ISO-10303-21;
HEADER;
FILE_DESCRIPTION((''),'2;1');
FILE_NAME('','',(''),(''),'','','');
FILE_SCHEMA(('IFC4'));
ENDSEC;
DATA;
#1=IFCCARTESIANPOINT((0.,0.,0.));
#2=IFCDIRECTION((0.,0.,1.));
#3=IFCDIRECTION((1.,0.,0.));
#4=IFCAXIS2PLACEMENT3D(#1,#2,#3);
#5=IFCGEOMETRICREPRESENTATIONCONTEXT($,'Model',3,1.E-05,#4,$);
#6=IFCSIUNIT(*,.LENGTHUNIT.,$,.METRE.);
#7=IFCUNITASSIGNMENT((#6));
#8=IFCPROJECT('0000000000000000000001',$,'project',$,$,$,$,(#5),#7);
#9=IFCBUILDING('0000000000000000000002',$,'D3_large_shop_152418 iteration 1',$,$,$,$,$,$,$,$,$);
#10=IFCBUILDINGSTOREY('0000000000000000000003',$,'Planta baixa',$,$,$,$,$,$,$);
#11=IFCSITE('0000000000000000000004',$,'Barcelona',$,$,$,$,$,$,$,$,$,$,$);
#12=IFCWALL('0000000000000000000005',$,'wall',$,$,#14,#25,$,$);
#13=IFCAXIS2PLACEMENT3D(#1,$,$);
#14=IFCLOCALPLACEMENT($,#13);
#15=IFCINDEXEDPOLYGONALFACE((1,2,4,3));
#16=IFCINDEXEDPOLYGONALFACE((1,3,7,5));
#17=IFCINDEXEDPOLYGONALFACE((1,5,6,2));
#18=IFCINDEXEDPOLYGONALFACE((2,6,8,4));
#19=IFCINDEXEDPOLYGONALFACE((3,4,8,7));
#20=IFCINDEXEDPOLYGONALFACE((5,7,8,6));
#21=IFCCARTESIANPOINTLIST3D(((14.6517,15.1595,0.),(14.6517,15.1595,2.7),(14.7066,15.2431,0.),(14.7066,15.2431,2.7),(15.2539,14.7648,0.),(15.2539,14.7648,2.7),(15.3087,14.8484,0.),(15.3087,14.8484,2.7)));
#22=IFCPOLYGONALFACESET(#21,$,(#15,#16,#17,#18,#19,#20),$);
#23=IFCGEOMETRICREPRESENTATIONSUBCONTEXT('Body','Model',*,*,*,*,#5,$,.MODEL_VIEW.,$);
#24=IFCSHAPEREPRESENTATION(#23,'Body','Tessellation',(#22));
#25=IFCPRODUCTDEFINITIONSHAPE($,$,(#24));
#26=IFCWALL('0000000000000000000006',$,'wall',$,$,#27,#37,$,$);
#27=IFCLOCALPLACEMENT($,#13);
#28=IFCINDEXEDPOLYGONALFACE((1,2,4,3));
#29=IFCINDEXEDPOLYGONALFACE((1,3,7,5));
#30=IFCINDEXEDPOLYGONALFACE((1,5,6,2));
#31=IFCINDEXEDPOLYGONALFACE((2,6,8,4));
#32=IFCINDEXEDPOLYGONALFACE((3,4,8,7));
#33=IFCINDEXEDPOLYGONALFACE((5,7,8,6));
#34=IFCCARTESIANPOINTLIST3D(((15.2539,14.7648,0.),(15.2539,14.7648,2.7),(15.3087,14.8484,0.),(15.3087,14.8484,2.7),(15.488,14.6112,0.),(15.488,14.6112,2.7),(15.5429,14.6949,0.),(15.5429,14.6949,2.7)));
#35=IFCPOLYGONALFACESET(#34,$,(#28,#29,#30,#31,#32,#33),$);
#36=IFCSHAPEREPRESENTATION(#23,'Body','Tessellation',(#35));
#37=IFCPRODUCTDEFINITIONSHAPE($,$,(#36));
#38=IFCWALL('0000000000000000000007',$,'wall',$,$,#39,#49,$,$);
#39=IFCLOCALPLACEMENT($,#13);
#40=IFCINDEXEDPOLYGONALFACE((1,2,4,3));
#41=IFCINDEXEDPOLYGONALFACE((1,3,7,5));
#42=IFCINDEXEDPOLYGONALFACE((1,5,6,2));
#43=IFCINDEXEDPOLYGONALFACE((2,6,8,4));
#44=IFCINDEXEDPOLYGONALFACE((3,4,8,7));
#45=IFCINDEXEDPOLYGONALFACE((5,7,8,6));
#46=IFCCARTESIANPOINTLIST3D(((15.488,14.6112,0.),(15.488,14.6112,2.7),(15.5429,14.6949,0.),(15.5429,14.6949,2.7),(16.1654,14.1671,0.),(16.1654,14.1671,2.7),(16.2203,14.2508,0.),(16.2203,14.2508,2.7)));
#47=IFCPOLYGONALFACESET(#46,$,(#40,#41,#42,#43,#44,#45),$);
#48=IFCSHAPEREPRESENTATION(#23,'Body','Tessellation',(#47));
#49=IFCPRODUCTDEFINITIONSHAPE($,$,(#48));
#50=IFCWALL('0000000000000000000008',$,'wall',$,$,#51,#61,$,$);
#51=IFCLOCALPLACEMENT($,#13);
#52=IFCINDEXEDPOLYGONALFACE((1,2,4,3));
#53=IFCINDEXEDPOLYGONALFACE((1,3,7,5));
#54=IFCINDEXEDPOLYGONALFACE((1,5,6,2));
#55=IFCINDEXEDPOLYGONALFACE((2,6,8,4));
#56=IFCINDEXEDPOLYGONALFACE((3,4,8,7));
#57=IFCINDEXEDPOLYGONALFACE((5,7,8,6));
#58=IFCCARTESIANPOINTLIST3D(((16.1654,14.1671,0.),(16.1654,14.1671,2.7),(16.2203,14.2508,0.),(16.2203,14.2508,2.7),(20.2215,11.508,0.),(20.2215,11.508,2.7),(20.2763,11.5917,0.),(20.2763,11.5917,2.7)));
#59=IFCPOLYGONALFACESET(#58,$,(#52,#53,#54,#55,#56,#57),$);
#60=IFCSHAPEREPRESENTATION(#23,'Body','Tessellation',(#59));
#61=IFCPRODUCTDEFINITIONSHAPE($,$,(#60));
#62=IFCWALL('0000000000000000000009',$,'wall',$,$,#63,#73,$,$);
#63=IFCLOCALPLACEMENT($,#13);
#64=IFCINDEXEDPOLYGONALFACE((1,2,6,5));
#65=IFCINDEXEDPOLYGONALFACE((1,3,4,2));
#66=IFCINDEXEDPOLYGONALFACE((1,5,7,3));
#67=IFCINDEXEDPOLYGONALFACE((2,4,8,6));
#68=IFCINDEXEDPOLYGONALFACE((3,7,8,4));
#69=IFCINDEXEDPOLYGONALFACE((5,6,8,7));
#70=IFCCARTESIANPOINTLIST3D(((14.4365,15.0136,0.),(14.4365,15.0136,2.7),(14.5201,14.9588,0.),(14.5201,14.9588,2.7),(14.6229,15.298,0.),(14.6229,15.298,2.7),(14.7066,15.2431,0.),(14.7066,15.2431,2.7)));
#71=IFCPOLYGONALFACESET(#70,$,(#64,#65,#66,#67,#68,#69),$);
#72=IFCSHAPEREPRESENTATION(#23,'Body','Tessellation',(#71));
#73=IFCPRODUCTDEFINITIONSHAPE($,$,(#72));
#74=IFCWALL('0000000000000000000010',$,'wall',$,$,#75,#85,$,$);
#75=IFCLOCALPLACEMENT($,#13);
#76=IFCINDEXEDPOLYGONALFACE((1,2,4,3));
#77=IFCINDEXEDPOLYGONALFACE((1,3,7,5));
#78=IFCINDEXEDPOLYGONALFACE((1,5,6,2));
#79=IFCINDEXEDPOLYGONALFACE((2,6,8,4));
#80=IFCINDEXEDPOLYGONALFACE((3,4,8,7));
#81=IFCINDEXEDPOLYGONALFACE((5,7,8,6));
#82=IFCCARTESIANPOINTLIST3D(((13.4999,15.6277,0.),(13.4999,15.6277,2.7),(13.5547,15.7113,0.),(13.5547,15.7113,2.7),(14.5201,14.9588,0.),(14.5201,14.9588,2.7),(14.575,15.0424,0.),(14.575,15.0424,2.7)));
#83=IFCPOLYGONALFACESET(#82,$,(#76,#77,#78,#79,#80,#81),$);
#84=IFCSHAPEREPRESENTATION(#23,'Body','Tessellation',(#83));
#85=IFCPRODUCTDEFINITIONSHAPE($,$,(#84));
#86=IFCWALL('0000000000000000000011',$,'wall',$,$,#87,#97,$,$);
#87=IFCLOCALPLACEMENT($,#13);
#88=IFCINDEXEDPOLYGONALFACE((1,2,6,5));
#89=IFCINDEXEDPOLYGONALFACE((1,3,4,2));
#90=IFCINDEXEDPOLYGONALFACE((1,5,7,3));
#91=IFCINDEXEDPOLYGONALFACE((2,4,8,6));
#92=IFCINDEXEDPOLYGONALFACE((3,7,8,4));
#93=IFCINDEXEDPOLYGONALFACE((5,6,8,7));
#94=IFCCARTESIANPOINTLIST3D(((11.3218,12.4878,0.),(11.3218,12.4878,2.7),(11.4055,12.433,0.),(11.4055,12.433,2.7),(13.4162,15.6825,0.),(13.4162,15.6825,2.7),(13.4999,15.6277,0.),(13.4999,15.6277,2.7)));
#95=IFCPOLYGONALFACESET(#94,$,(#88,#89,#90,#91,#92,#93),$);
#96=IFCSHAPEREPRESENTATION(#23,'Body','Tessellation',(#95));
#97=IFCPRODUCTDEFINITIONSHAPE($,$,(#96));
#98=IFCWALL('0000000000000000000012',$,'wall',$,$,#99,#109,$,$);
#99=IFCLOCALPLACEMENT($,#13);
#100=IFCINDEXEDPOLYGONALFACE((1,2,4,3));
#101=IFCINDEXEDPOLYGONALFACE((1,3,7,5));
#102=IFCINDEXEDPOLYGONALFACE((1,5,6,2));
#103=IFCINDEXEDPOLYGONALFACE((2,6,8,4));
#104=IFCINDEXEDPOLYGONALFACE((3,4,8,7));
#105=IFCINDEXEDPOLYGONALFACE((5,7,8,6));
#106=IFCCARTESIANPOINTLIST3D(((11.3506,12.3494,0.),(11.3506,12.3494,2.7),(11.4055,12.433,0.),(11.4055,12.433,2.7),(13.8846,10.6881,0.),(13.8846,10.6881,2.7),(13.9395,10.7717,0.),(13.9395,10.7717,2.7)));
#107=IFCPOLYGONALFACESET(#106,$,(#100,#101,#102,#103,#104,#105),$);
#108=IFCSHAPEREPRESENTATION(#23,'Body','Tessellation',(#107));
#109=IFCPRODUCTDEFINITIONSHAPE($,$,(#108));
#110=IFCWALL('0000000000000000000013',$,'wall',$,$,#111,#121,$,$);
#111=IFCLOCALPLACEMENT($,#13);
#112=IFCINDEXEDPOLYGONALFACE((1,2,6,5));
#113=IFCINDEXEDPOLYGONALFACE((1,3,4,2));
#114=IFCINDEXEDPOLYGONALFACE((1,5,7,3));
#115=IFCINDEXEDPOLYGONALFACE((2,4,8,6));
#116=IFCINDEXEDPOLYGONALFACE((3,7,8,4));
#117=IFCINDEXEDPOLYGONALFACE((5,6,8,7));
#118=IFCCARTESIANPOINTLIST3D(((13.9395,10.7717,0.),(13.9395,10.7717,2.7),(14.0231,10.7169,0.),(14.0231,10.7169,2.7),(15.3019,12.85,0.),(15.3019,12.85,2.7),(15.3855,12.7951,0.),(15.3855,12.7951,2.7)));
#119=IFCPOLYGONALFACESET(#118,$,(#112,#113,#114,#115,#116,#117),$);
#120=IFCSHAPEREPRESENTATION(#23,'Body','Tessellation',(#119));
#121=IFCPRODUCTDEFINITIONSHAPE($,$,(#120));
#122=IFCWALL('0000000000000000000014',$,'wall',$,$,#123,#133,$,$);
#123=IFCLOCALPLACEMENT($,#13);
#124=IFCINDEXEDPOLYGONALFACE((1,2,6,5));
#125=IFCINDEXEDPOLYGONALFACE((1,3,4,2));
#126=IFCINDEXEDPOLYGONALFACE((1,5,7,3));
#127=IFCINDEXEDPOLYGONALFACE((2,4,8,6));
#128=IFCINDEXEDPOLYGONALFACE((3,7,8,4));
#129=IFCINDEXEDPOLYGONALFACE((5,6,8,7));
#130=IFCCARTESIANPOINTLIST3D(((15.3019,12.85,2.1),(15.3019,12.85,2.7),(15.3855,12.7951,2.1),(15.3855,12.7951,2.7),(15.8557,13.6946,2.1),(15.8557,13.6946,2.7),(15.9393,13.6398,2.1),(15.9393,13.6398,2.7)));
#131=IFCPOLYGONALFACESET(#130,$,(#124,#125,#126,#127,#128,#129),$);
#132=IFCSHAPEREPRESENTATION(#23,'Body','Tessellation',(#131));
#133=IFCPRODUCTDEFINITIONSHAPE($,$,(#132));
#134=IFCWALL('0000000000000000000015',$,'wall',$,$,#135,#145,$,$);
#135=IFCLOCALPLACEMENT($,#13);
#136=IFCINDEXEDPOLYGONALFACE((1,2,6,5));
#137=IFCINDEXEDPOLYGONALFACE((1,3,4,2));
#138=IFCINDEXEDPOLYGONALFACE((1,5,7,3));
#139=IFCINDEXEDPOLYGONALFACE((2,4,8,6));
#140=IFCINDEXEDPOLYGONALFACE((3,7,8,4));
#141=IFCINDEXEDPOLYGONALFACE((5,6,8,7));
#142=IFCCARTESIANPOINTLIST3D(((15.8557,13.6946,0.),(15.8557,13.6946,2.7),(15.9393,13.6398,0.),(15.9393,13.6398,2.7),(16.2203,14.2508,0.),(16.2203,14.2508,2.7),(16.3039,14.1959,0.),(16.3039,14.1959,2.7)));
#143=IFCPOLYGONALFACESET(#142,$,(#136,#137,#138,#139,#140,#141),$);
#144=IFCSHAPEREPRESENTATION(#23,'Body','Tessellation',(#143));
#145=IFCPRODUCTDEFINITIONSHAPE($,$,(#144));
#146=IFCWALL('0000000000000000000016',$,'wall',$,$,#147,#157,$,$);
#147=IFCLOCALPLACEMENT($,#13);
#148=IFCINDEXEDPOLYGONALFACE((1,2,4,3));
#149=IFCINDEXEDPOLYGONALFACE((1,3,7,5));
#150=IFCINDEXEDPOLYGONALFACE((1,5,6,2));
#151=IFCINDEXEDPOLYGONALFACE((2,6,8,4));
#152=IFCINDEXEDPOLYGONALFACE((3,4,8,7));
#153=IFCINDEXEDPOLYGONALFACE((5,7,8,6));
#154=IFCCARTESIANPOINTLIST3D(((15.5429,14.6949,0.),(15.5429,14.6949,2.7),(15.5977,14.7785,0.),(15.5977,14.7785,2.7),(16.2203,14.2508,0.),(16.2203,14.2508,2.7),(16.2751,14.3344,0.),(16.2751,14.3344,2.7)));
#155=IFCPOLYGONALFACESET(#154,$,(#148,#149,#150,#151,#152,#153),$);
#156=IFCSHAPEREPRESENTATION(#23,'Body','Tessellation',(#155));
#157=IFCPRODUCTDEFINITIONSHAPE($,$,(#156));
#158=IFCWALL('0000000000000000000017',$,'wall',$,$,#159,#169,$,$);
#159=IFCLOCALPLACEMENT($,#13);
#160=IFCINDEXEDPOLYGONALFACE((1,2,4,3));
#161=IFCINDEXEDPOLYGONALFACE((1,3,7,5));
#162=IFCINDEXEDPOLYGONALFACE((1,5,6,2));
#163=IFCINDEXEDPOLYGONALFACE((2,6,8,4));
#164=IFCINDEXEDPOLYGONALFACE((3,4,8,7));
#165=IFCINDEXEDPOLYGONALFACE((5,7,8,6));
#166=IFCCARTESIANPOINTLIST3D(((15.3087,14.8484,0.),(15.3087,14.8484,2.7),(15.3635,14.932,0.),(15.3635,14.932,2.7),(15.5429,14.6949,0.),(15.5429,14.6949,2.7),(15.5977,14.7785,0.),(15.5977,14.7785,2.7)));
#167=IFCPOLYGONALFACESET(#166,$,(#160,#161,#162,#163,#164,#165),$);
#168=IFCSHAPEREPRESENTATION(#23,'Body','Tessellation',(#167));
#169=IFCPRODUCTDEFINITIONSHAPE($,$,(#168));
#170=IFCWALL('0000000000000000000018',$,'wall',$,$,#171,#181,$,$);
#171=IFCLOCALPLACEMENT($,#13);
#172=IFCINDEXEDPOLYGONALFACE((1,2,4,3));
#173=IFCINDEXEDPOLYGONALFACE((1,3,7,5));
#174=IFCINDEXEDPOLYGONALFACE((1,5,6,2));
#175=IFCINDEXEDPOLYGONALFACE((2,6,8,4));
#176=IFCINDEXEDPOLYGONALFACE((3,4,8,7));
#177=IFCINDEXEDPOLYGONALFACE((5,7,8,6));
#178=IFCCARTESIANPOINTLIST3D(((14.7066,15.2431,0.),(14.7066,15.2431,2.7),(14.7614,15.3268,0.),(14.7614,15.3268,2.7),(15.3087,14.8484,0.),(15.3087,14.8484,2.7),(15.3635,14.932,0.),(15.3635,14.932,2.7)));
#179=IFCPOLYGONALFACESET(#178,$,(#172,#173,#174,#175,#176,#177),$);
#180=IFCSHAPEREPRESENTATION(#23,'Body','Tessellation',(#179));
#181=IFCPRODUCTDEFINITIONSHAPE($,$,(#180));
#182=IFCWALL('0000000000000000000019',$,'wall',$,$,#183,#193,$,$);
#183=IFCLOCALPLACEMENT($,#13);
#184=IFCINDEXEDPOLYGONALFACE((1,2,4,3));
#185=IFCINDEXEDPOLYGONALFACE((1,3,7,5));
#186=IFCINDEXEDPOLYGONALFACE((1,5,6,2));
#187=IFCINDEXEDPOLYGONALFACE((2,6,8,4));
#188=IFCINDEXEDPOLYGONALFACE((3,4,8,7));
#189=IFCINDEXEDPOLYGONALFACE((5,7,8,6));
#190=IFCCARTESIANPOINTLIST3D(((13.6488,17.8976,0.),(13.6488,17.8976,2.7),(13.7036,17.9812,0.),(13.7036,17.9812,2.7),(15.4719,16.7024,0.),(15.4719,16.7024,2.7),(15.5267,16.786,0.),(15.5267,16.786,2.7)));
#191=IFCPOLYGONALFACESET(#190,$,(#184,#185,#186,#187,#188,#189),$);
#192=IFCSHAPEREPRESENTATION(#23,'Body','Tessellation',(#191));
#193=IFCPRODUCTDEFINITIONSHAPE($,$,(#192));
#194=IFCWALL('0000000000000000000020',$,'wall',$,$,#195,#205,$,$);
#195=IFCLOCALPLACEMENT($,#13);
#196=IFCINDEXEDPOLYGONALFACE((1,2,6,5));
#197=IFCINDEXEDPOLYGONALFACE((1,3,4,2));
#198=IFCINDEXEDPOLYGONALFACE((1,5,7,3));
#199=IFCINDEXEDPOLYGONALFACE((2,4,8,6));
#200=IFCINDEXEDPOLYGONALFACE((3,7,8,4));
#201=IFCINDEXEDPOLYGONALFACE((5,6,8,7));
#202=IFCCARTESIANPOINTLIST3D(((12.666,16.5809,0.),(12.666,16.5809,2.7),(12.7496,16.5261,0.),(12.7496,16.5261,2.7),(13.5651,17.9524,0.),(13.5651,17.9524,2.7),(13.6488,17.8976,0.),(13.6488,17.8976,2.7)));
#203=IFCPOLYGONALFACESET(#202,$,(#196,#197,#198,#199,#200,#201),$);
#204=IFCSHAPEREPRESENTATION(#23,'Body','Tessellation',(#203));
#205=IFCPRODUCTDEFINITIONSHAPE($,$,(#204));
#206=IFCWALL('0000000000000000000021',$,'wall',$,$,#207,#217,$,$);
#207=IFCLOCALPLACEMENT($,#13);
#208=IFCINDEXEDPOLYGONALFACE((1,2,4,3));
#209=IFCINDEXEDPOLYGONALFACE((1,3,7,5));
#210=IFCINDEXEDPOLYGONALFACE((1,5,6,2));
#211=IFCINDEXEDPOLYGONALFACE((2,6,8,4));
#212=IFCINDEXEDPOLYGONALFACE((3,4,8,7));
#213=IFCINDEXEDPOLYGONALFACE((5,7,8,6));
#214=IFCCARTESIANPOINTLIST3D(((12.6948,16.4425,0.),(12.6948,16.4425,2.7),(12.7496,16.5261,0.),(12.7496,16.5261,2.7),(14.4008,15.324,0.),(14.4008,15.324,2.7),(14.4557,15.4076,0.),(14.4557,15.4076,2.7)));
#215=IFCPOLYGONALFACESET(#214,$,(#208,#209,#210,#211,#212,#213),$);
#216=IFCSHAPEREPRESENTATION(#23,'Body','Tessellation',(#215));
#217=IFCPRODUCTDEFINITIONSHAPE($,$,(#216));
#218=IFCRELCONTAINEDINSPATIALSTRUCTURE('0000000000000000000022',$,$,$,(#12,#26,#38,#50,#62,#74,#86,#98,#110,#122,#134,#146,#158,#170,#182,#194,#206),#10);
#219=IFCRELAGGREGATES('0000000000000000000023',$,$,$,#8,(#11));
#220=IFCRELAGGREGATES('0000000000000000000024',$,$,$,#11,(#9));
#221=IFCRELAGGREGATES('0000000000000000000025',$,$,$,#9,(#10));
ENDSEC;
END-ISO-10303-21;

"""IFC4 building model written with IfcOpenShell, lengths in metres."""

from ifc_helpers import new_model, si_unit, frame, origin, origin_with_axes, place, context, subcontext, project, spatial, polyline, outline, extrude, element, save


model = new_model("IFC4")

# Units and contexts
model_context = context("Model", 3, precision=1e-05, world=origin_with_axes())
body_context = subcontext(model_context, "Body", "Model", "MODEL_VIEW")
ifc_project = project(units=[si_unit("LENGTHUNIT", "METRE")], contexts=[model_context])

# Site, building, storey
site = spatial("IfcSite", under=ifc_project, Name="Barcelona")
building = spatial("IfcBuilding", under=site, Name="D3_large_shop_152418 iteration 1")
storey = spatial("IfcBuildingStorey", under=building, Name="Planta baixa")

# Walls
wall_1_placement = place(None, origin_with_axes())
element("IfcWall", 1, at=wall_1_placement, inside=storey, Name="wall", context=body_context, shape_type="SweptSolid", body=[
    extrude(outline(polyline([(14.7066, 15.2431), (15.3087, 14.8484), (15.2539, 14.7648), (14.6517, 15.1595), (14.7066, 15.2431)])), origin(), (0.0, 0.0, 1.0), 2.7),
])
wall_2_placement = place(None, origin_with_axes())
element("IfcWall", 2, at=wall_2_placement, inside=storey, Name="wall", context=body_context, shape_type="SweptSolid", body=[
    extrude(outline(polyline([(15.3087, 14.8484), (15.5429, 14.6949), (15.488, 14.6112), (15.2539, 14.7648), (15.3087, 14.8484)])), origin(), (0.0, 0.0, 1.0), 2.7),
])
wall_3_placement = place(None, origin_with_axes())
element("IfcWall", 3, at=wall_3_placement, inside=storey, Name="wall", context=body_context, shape_type="SweptSolid", body=[
    extrude(outline(polyline([(15.5429, 14.6949), (16.2203, 14.2508), (16.1654, 14.1671), (15.488, 14.6112), (15.5429, 14.6949)])), origin(), (0.0, 0.0, 1.0), 2.7),
])
wall_4_placement = place(None, origin_with_axes())
element("IfcWall", 4, at=wall_4_placement, inside=storey, Name="wall", context=body_context, shape_type="SweptSolid", body=[
    extrude(outline(polyline([(16.2203, 14.2508), (20.2763, 11.5917), (20.2215, 11.508), (16.1654, 14.1671), (16.2203, 14.2508)])), origin(), (0.0, 0.0, 1.0), 2.7),
])
wall_5_placement = place(None, origin_with_axes())
element("IfcWall", 5, at=wall_5_placement, inside=storey, Name="wall", context=body_context, shape_type="SweptSolid", body=[
    extrude(outline(polyline([(14.7066, 15.2431), (14.5201, 14.9588), (14.4365, 15.0136), (14.6229, 15.298), (14.7066, 15.2431)])), origin(), (0.0, 0.0, 1.0), 2.7),
])
wall_6_placement = place(None, origin_with_axes())
element("IfcWall", 6, at=wall_6_placement, inside=storey, Name="wall", context=body_context, shape_type="SweptSolid", body=[
    extrude(outline(polyline([(14.5201, 14.9588), (13.4999, 15.6277), (13.5547, 15.7113), (14.575, 15.0424), (14.5201, 14.9588)])), origin(), (0.0, 0.0, 1.0), 2.7),
])
wall_7_placement = place(None, origin_with_axes())
element("IfcWall", 7, at=wall_7_placement, inside=storey, Name="wall", context=body_context, shape_type="SweptSolid", body=[
    extrude(outline(polyline([(13.4999, 15.6277), (11.4055, 12.433), (11.3218, 12.4878), (13.4162, 15.6825), (13.4999, 15.6277)])), origin(), (0.0, 0.0, 1.0), 2.7),
])
wall_8_placement = place(None, origin_with_axes())
element("IfcWall", 8, at=wall_8_placement, inside=storey, Name="wall", context=body_context, shape_type="SweptSolid", body=[
    extrude(outline(polyline([(11.4055, 12.433), (13.9395, 10.7717), (13.8846, 10.6881), (11.3506, 12.3494), (11.4055, 12.433)])), origin(), (0.0, 0.0, 1.0), 2.7),
])
wall_9_placement = place(None, origin_with_axes())
element("IfcWall", 9, at=wall_9_placement, inside=storey, Name="wall", context=body_context, shape_type="SweptSolid", body=[
    extrude(outline(polyline([(13.9395, 10.7717), (15.3019, 12.85), (15.3855, 12.7951), (14.0231, 10.7169), (13.9395, 10.7717)])), origin(), (0.0, 0.0, 1.0), 2.7),
])
wall_10_placement = place(None, origin_with_axes())
element("IfcWall", 10, at=wall_10_placement, inside=storey, Name="wall", context=body_context, shape_type="SweptSolid", body=[
    extrude(outline(polyline([(15.3019, 12.85), (15.8557, 13.6946), (15.9393, 13.6398), (15.3855, 12.7951), (15.3019, 12.85)])), frame((0.0, 0.0, 2.1)), (0.0, 0.0, 1.0), 0.6),
])
wall_11_placement = place(None, origin_with_axes())
element("IfcWall", 11, at=wall_11_placement, inside=storey, Name="wall", context=body_context, shape_type="SweptSolid", body=[
    extrude(outline(polyline([(15.8557, 13.6946), (16.2203, 14.2508), (16.3039, 14.1959), (15.9393, 13.6398), (15.8557, 13.6946)])), origin(), (0.0, 0.0, 1.0), 2.7),
])
wall_12_placement = place(None, origin_with_axes())
element("IfcWall", 12, at=wall_12_placement, inside=storey, Name="wall", context=body_context, shape_type="SweptSolid", body=[
    extrude(outline(polyline([(16.2203, 14.2508), (15.5429, 14.6949), (15.5977, 14.7785), (16.2751, 14.3344), (16.2203, 14.2508)])), origin(), (0.0, 0.0, 1.0), 2.7),
])
wall_13_placement = place(None, origin_with_axes())
element("IfcWall", 13, at=wall_13_placement, inside=storey, Name="wall", context=body_context, shape_type="SweptSolid", body=[
    extrude(outline(polyline([(15.5429, 14.6949), (15.3087, 14.8484), (15.3635, 14.932), (15.5977, 14.7785), (15.5429, 14.6949)])), origin(), (0.0, 0.0, 1.0), 2.7),
])
wall_14_placement = place(None, origin_with_axes())
element("IfcWall", 14, at=wall_14_placement, inside=storey, Name="wall", context=body_context, shape_type="SweptSolid", body=[
    extrude(outline(polyline([(15.3087, 14.8484), (14.7066, 15.2431), (14.7614, 15.3268), (15.3635, 14.932), (15.3087, 14.8484)])), origin(), (0.0, 0.0, 1.0), 2.7),
])
wall_15_placement = place(None, origin_with_axes())
element("IfcWall", 15, at=wall_15_placement, inside=storey, Name="wall", context=body_context, shape_type="SweptSolid", body=[
    extrude(outline(polyline([(15.4719, 16.7024), (13.6488, 17.8976), (13.7036, 17.9812), (15.5267, 16.786), (15.4719, 16.7024)])), origin(), (0.0, 0.0, 1.0), 2.7),
])
wall_16_placement = place(None, origin_with_axes())
element("IfcWall", 16, at=wall_16_placement, inside=storey, Name="wall", context=body_context, shape_type="SweptSolid", body=[
    extrude(outline(polyline([(13.6488, 17.8976), (12.7496, 16.5261), (12.666, 16.5809), (13.5651, 17.9524), (13.6488, 17.8976)])), origin(), (0.0, 0.0, 1.0), 2.7),
])
wall_17_placement = place(None, origin_with_axes())
element("IfcWall", 17, at=wall_17_placement, inside=storey, Name="wall", context=body_context, shape_type="SweptSolid", body=[
    extrude(outline(polyline([(12.7496, 16.5261), (14.4557, 15.4076), (14.4008, 15.324), (12.6948, 16.4425), (12.7496, 16.5261)])), origin(), (0.0, 0.0, 1.0), 2.7),
])

save(model, "model.ifc")
